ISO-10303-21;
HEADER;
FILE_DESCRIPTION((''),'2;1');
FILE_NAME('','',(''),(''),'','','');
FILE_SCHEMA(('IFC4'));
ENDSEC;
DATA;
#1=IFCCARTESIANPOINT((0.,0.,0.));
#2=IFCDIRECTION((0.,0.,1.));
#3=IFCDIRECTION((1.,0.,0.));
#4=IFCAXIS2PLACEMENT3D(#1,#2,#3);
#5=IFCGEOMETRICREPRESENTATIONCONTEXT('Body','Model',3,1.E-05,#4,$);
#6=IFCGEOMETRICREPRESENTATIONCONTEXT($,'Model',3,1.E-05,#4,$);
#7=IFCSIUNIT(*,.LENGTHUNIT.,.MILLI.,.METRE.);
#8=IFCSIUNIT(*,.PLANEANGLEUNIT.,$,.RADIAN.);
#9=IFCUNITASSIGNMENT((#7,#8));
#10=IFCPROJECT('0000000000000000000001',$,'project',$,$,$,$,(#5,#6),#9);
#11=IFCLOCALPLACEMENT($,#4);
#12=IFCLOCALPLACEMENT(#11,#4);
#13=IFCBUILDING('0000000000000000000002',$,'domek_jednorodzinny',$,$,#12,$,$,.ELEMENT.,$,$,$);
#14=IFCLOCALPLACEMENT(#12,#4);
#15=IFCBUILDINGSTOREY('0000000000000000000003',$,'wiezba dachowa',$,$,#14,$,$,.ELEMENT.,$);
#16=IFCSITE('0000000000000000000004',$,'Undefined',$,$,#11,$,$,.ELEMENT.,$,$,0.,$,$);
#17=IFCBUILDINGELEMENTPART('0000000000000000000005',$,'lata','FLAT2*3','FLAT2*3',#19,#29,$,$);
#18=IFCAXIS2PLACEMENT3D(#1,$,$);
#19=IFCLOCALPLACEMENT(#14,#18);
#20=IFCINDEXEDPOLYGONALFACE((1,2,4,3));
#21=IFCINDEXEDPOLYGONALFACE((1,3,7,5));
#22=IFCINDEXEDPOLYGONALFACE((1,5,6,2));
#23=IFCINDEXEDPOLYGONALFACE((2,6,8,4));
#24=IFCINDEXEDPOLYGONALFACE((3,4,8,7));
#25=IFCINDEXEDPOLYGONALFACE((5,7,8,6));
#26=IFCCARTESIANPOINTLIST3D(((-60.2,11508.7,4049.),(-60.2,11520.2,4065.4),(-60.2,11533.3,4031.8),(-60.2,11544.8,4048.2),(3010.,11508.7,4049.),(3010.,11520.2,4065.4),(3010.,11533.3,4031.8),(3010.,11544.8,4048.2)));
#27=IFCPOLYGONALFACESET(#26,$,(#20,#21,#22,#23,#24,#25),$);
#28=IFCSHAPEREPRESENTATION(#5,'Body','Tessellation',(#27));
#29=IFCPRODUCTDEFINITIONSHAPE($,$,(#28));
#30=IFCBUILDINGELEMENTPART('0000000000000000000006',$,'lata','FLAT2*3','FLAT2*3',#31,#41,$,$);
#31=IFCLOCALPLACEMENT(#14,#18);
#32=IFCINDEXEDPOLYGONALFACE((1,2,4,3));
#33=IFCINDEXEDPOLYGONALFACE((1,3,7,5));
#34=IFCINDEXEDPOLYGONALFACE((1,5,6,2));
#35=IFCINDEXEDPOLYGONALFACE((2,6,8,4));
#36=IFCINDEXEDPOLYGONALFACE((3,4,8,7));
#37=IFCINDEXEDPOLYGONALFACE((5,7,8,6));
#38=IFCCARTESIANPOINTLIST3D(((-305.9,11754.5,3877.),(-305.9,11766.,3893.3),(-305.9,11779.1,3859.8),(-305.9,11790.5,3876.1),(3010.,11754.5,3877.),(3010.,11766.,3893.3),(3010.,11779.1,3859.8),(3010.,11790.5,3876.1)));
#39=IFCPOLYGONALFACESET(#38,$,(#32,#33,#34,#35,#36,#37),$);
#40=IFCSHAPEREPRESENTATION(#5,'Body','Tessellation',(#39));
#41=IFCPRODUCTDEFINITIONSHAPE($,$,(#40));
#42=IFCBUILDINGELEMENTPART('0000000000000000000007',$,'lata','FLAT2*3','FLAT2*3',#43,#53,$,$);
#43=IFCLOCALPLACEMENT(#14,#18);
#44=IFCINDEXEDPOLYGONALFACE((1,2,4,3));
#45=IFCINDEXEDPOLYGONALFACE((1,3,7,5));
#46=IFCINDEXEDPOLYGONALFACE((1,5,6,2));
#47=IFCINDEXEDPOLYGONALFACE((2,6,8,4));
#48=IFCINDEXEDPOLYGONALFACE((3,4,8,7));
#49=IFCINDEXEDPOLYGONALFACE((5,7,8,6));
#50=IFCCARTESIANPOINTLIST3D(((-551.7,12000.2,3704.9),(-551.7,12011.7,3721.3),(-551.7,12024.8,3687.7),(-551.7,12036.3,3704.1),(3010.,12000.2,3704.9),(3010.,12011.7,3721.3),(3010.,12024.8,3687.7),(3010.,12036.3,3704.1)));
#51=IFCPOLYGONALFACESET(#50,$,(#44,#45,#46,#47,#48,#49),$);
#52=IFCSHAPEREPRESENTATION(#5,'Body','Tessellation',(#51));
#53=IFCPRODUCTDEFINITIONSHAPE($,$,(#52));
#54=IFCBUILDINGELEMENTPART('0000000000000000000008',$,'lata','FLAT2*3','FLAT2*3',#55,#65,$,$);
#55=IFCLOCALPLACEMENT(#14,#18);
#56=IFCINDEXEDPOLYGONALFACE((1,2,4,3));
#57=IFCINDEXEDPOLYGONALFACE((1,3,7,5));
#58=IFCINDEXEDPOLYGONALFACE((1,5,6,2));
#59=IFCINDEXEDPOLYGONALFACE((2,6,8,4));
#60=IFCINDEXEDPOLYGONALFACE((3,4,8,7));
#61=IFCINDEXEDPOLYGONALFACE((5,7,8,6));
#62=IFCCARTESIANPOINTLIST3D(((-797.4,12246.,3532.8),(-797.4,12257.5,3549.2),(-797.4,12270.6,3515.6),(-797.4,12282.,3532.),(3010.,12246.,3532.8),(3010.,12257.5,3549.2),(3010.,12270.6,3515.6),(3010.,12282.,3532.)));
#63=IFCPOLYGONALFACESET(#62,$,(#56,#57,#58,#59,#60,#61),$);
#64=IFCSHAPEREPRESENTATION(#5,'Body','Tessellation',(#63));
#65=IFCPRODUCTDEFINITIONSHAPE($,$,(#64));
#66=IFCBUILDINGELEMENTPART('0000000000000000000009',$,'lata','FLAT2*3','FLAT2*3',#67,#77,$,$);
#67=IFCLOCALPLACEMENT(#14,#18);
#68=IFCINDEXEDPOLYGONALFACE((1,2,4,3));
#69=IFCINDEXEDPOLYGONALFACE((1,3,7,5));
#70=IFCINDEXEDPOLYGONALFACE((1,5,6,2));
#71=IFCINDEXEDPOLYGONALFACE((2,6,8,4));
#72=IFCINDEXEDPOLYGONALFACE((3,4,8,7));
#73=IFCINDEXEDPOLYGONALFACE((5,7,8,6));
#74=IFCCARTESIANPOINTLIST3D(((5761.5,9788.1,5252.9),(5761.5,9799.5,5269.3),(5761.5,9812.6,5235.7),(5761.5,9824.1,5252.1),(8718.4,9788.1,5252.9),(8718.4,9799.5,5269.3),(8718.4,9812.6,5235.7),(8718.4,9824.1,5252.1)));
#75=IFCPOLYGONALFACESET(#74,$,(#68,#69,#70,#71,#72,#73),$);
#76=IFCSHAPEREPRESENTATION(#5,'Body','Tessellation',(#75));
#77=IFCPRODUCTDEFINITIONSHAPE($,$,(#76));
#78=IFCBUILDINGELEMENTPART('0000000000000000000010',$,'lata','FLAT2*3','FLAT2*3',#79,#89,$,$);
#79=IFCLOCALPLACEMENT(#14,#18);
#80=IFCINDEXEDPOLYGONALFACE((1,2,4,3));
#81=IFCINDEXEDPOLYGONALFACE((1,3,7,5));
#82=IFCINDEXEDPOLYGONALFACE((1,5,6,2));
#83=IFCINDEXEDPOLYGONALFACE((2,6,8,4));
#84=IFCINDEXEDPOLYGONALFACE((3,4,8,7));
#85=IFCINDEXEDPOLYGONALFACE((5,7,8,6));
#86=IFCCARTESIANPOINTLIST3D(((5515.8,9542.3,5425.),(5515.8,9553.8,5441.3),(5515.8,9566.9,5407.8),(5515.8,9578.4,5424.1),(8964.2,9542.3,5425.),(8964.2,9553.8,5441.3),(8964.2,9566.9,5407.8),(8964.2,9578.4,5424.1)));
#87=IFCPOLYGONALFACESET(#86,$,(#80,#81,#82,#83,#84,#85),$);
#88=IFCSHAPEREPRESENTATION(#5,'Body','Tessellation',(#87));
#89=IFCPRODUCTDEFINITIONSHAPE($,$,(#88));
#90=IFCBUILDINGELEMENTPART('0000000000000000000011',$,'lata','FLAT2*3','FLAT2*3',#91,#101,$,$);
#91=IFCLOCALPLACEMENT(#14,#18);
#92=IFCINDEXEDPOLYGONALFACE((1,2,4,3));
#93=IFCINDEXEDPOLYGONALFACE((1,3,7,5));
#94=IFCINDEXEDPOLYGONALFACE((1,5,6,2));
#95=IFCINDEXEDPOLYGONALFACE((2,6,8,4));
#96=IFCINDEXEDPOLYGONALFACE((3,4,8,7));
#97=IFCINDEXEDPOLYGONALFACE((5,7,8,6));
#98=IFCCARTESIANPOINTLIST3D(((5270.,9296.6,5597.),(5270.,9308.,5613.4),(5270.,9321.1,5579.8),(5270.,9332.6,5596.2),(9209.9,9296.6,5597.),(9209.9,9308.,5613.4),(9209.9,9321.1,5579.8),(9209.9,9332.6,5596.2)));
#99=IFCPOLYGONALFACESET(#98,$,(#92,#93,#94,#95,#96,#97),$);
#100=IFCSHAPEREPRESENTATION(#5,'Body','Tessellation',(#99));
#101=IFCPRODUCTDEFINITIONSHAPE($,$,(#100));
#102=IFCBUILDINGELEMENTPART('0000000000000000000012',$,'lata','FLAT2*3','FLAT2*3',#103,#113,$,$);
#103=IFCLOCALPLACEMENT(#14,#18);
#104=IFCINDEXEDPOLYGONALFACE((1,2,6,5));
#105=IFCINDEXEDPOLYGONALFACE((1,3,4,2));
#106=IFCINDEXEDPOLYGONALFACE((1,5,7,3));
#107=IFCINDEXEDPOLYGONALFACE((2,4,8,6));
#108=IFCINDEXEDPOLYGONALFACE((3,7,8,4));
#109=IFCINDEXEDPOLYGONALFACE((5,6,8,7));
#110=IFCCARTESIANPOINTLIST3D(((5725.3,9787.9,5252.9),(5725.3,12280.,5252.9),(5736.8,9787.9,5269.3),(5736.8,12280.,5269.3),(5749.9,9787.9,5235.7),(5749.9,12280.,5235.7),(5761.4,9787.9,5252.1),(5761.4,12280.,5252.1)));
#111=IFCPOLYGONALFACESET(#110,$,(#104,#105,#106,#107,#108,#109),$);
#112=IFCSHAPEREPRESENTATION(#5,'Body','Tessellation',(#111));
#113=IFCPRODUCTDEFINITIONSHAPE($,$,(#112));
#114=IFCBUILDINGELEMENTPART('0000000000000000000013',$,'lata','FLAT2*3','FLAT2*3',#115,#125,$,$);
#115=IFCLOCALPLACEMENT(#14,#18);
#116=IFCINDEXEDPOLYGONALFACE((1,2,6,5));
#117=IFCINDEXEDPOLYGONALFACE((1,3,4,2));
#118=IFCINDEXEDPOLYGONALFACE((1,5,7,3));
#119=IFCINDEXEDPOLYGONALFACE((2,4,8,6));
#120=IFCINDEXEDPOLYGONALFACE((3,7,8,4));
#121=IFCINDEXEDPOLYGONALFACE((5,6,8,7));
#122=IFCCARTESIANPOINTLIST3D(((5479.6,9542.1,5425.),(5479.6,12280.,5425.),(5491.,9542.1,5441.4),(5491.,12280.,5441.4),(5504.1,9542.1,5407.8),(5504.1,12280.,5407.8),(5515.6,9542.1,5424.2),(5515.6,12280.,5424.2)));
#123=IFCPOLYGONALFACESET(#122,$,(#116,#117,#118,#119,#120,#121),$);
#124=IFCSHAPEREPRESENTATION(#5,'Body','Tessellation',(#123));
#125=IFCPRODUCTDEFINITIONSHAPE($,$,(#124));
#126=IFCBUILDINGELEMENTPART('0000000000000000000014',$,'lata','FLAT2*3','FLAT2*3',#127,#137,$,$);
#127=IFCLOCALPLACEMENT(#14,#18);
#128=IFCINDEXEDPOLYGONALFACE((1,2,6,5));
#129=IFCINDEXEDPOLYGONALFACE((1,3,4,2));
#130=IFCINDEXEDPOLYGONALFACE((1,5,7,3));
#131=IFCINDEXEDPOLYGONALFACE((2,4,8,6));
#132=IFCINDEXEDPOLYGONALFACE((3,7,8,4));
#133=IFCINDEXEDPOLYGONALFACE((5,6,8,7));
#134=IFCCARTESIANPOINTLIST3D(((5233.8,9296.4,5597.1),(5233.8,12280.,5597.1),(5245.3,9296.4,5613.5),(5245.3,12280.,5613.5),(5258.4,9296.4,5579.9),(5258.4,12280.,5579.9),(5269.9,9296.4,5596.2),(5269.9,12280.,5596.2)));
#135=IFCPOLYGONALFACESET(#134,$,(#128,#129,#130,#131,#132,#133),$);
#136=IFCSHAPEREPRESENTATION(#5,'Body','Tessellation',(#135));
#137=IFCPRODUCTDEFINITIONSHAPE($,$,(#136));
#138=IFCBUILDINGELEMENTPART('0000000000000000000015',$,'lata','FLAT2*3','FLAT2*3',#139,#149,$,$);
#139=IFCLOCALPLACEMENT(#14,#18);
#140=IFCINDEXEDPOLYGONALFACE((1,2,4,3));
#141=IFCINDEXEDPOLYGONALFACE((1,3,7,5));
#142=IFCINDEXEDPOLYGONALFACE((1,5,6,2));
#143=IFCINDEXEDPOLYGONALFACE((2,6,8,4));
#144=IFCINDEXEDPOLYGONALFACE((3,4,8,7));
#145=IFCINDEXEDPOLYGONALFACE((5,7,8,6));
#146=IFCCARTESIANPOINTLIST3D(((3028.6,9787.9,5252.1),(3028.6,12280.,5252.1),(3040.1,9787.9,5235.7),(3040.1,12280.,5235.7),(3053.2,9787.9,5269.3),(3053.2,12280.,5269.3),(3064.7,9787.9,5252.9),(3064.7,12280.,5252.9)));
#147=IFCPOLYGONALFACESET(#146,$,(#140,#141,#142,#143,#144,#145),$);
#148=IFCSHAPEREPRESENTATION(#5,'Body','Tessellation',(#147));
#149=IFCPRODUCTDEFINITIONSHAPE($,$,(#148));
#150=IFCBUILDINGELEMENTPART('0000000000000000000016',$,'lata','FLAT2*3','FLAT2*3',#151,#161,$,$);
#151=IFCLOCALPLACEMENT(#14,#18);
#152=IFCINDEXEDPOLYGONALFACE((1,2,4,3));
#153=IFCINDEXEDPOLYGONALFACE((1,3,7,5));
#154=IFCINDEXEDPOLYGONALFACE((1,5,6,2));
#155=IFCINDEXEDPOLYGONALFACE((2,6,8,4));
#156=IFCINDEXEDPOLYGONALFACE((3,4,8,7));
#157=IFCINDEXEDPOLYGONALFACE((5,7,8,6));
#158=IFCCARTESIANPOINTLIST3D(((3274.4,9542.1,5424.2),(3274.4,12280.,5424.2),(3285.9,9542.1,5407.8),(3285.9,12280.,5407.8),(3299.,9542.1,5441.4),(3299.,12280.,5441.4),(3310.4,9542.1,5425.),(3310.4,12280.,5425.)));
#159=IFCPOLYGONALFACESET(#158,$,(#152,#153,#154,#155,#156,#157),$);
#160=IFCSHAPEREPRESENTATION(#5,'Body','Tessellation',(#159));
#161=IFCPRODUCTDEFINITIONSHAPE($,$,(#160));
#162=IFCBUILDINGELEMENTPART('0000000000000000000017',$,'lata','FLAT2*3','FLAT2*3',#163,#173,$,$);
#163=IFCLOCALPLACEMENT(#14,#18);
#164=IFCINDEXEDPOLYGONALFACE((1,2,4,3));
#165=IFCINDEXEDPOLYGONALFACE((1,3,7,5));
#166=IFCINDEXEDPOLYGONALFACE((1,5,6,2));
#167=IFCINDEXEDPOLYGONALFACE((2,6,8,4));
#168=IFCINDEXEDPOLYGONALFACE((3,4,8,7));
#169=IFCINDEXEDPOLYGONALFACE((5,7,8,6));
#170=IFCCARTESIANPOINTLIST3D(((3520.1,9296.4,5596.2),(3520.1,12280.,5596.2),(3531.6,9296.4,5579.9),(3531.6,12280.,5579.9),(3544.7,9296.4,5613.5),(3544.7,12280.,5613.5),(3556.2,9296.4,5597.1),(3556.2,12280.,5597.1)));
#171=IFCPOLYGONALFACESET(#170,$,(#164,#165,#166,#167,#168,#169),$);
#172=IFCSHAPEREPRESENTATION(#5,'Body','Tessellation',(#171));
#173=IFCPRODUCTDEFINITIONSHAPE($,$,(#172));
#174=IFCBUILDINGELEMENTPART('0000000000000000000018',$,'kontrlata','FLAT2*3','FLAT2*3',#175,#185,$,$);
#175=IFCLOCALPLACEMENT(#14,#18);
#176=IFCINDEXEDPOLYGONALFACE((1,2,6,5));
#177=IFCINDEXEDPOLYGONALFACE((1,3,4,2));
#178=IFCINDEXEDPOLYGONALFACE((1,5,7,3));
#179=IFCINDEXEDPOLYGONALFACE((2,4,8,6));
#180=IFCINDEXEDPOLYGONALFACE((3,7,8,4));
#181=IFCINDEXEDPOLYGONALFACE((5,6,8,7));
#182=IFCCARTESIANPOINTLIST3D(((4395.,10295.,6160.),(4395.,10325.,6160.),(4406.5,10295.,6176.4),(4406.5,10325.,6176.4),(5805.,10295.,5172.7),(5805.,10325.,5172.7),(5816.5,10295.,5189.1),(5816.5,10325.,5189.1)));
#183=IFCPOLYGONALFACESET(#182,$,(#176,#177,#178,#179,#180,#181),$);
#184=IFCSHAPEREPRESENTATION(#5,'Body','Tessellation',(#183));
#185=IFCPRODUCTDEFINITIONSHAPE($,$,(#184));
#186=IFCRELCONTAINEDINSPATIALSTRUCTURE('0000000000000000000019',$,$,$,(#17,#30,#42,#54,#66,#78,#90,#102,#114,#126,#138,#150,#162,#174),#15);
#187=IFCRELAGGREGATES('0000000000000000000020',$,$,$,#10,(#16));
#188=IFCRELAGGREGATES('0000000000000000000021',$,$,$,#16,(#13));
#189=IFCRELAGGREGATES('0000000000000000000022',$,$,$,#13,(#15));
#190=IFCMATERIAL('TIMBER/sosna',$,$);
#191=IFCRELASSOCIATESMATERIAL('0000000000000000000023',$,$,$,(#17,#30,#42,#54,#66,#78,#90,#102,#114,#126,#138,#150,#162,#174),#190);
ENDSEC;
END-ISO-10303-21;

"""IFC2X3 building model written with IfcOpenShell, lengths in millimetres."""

from ifc_helpers import new_model, si_unit, frame, origin_with_axes, origin_2d_with_axis, place, context, project, spatial, rectangle, extrude, material, element, save


model = new_model("IFC2X3")

# Units and contexts
model_context_1 = context("Model", 3, precision=1e-05, world=origin_with_axes(), identifier="Body")
model_context_2 = context("Model", 3, precision=1e-05, world=origin_with_axes())
ifc_project = project(units=[si_unit("LENGTHUNIT", "METRE", prefix="MILLI"), si_unit("PLANEANGLEUNIT", "RADIAN")], contexts=[model_context_1, model_context_2])

# Site, building, storey
site_placement = place(None, origin_with_axes())
site = spatial("IfcSite", under=ifc_project, at=site_placement, Name="Undefined", CompositionType="ELEMENT", RefElevation=0.0)
building_placement = place(site_placement, origin_with_axes())
building = spatial("IfcBuilding", under=site, at=building_placement, Name="domek_jednorodzinny", CompositionType="ELEMENT")
storey_placement = place(building_placement, origin_with_axes())
storey = spatial("IfcBuildingStorey", under=building, at=storey_placement, Name="wiezba dachowa", CompositionType="ELEMENT")

# Building element parts
ifc_material = material(Name="TIMBER/sosna")
building_element_part_1_placement = place(storey_placement, frame((3010.0, 11526.8, 4048.6), z_axis=(0.0, -0.819154, 0.573574), x_axis=(-1.0, 0.0, 0.0)))
element("IfcBuildingElementPart", 1, at=building_element_part_1_placement, inside=storey, material=ifc_material, Name="lata", Description="FLAT2*3", ObjectType="FLAT2*3", context=model_context_1, shape_type="SweptSolid", body=[
    extrude(rectangle(XDim=20.0, YDim=30.0, at=origin_2d_with_axis()), frame((3070.2, 0.0, 0.0), z_axis=(-1.0, 0.0, 0.0), x_axis=(0.0, -1.0, 0.0)), (0.0, 0.0, 1.0), 3070.2),
])
building_element_part_2_placement = place(storey_placement, frame((3010.0, 11772.5, 3876.5), z_axis=(0.0, -0.819154, 0.573574), x_axis=(-1.0, 0.0, 0.0)))
element("IfcBuildingElementPart", 2, at=building_element_part_2_placement, inside=storey, material=ifc_material, Name="lata", Description="FLAT2*3", ObjectType="FLAT2*3", context=model_context_1, shape_type="SweptSolid", body=[
    extrude(rectangle(XDim=20.0, YDim=30.0, at=origin_2d_with_axis()), frame((3316.0, 0.0, 0.0), z_axis=(-1.0, 0.0, 0.0), x_axis=(0.0, -1.0, 0.0)), (0.0, 0.0, 1.0), 3316.0),
])
building_element_part_3_placement = place(storey_placement, frame((3010.0, 12018.3, 3704.5), z_axis=(0.0, -0.819154, 0.573574), x_axis=(-1.0, 0.0, 0.0)))
element("IfcBuildingElementPart", 3, at=building_element_part_3_placement, inside=storey, material=ifc_material, Name="lata", Description="FLAT2*3", ObjectType="FLAT2*3", context=model_context_1, shape_type="SweptSolid", body=[
    extrude(rectangle(XDim=20.0, YDim=30.0, at=origin_2d_with_axis()), frame((3561.7, 0.0, 0.0), z_axis=(-1.0, 0.0, 0.0), x_axis=(0.0, -1.0, 0.0)), (0.0, 0.0, 1.0), 3561.7),
])
building_element_part_4_placement = place(storey_placement, frame((3010.0, 12264.0, 3532.4), z_axis=(0.0, -0.819154, 0.573574), x_axis=(-1.0, 0.0, 0.0)))
element("IfcBuildingElementPart", 4, at=building_element_part_4_placement, inside=storey, material=ifc_material, Name="lata", Description="FLAT2*3", ObjectType="FLAT2*3", context=model_context_1, shape_type="SweptSolid", body=[
    extrude(rectangle(XDim=20.0, YDim=30.0, at=origin_2d_with_axis()), frame((3807.4, 0.0, 0.0), z_axis=(-1.0, 0.0, 0.0), x_axis=(0.0, -1.0, 0.0)), (0.0, 0.0, 1.0), 3807.4),
])
building_element_part_5_placement = place(storey_placement, frame((5761.5, 9806.1, 5252.5), z_axis=(0.0, -0.819154, 0.573574), x_axis=(1.0, 0.0, 0.0)))
element("IfcBuildingElementPart", 5, at=building_element_part_5_placement, inside=storey, material=ifc_material, Name="lata", Description="FLAT2*3", ObjectType="FLAT2*3", context=model_context_1, shape_type="SweptSolid", body=[
    extrude(rectangle(XDim=20.0, YDim=30.0, at=origin_2d_with_axis()), frame((2956.9, 0.0, 0.0), z_axis=(-1.0, 0.0, 0.0), x_axis=(0.0, -1.0, 0.0)), (0.0, 0.0, 1.0), 2956.9),
])
building_element_part_6_placement = place(storey_placement, frame((5515.8, 9560.3, 5424.5), z_axis=(0.0, -0.819154, 0.573574), x_axis=(1.0, 0.0, 0.0)))
element("IfcBuildingElementPart", 6, at=building_element_part_6_placement, inside=storey, material=ifc_material, Name="lata", Description="FLAT2*3", ObjectType="FLAT2*3", context=model_context_1, shape_type="SweptSolid", body=[
    extrude(rectangle(XDim=20.0, YDim=30.0, at=origin_2d_with_axis()), frame((3448.4, 0.0, 0.0), z_axis=(-1.0, 0.0, 0.0), x_axis=(0.0, -1.0, 0.0)), (0.0, 0.0, 1.0), 3448.4),
])
building_element_part_7_placement = place(storey_placement, frame((5270.0, 9314.6, 5596.6), z_axis=(0.0, -0.819154, 0.573574), x_axis=(1.0, 0.0, 0.0)))
element("IfcBuildingElementPart", 7, at=building_element_part_7_placement, inside=storey, material=ifc_material, Name="lata", Description="FLAT2*3", ObjectType="FLAT2*3", context=model_context_1, shape_type="SweptSolid", body=[
    extrude(rectangle(XDim=20.0, YDim=30.0, at=origin_2d_with_axis()), frame((3939.9, 0.0, 0.0), z_axis=(-1.0, 0.0, 0.0), x_axis=(0.0, -1.0, 0.0)), (0.0, 0.0, 1.0), 3939.9),
])
building_element_part_8_placement = place(storey_placement, frame((5743.3, 9787.9, 5252.5), z_axis=(-0.819152, 0.0, 0.573576), x_axis=(0.0, 1.0, 0.0)))
element("IfcBuildingElementPart", 8, at=building_element_part_8_placement, inside=storey, material=ifc_material, Name="lata", Description="FLAT2*3", ObjectType="FLAT2*3", context=model_context_1, shape_type="SweptSolid", body=[
    extrude(rectangle(XDim=20.0, YDim=30.0, at=origin_2d_with_axis()), frame((2492.1, 0.0, 0.0), z_axis=(-1.0, 0.0, 0.0), x_axis=(0.0, -1.0, 0.0)), (0.0, 0.0, 1.0), 2492.1),
])
building_element_part_9_placement = place(storey_placement, frame((5497.6, 9542.1, 5424.6), z_axis=(-0.819152, 0.0, 0.573576), x_axis=(0.0, 1.0, 0.0)))
element("IfcBuildingElementPart", 9, at=building_element_part_9_placement, inside=storey, material=ifc_material, Name="lata", Description="FLAT2*3", ObjectType="FLAT2*3", context=model_context_1, shape_type="SweptSolid", body=[
    extrude(rectangle(XDim=20.0, YDim=30.0, at=origin_2d_with_axis()), frame((2737.8, 0.0, 0.0), z_axis=(-1.0, 0.0, 0.0), x_axis=(0.0, -1.0, 0.0)), (0.0, 0.0, 1.0), 2737.8),
])
building_element_part_10_placement = place(storey_placement, frame((5251.8, 9296.4, 5596.7), z_axis=(-0.819152, 0.0, 0.573576), x_axis=(0.0, 1.0, 0.0)))
element("IfcBuildingElementPart", 10, at=building_element_part_10_placement, inside=storey, material=ifc_material, Name="lata", Description="FLAT2*3", ObjectType="FLAT2*3", context=model_context_1, shape_type="SweptSolid", body=[
    extrude(rectangle(XDim=20.0, YDim=30.0, at=origin_2d_with_axis()), frame((2983.6, 0.0, 0.0), z_axis=(-1.0, 0.0, 0.0), x_axis=(0.0, -1.0, 0.0)), (0.0, 0.0, 1.0), 2983.6),
])
building_element_part_11_placement = place(storey_placement, frame((3046.7, 9787.9, 5252.5), z_axis=(0.819152, 0.0, 0.573576), x_axis=(0.0, 1.0, 0.0)))
element("IfcBuildingElementPart", 11, at=building_element_part_11_placement, inside=storey, material=ifc_material, Name="lata", Description="FLAT2*3", ObjectType="FLAT2*3", context=model_context_1, shape_type="SweptSolid", body=[
    extrude(rectangle(XDim=20.0, YDim=30.0, at=origin_2d_with_axis()), frame((2492.1, 0.0, 0.0), z_axis=(-1.0, 0.0, 0.0), x_axis=(0.0, -1.0, 0.0)), (0.0, 0.0, 1.0), 2492.1),
])
building_element_part_12_placement = place(storey_placement, frame((3292.4, 9542.1, 5424.6), z_axis=(0.819152, 0.0, 0.573576), x_axis=(0.0, 1.0, 0.0)))
element("IfcBuildingElementPart", 12, at=building_element_part_12_placement, inside=storey, material=ifc_material, Name="lata", Description="FLAT2*3", ObjectType="FLAT2*3", context=model_context_1, shape_type="SweptSolid", body=[
    extrude(rectangle(XDim=20.0, YDim=30.0, at=origin_2d_with_axis()), frame((2737.8, 0.0, 0.0), z_axis=(-1.0, 0.0, 0.0), x_axis=(0.0, -1.0, 0.0)), (0.0, 0.0, 1.0), 2737.8),
])
building_element_part_13_placement = place(storey_placement, frame((3538.2, 9296.4, 5596.7), z_axis=(0.819152, 0.0, 0.573576), x_axis=(0.0, 1.0, 0.0)))
element("IfcBuildingElementPart", 13, at=building_element_part_13_placement, inside=storey, material=ifc_material, Name="lata", Description="FLAT2*3", ObjectType="FLAT2*3", context=model_context_1, shape_type="SweptSolid", body=[
    extrude(rectangle(XDim=20.0, YDim=30.0, at=origin_2d_with_axis()), frame((2983.6, 0.0, 0.0), z_axis=(-1.0, 0.0, 0.0), x_axis=(0.0, -1.0, 0.0)), (0.0, 0.0, 1.0), 2983.6),
])
for number, where, z_axis, x_axis, name in (
    (14, (4400.7, 10310.0, 6168.2), (0.0, -1.0, 0.0), (0.819151, 0.0, -0.573578), "kontrlata"),
):
    element("IfcBuildingElementPart", number, at=place(storey_placement, frame(where, z_axis=z_axis, x_axis=x_axis)), inside=storey, material=ifc_material, Name=name, Description="FLAT2*3", ObjectType="FLAT2*3", context=model_context_1, shape_type="SweptSolid", body=[
        extrude(rectangle(XDim=20.0, YDim=30.0, at=origin_2d_with_axis()), frame((1721.3, 0.0, 0.0), z_axis=(-1.0, 0.0, 0.0), x_axis=(0.0, -1.0, 0.0)), (0.0, 0.0, 1.0), 1721.3),
    ])

save(model, "model.ifc")
